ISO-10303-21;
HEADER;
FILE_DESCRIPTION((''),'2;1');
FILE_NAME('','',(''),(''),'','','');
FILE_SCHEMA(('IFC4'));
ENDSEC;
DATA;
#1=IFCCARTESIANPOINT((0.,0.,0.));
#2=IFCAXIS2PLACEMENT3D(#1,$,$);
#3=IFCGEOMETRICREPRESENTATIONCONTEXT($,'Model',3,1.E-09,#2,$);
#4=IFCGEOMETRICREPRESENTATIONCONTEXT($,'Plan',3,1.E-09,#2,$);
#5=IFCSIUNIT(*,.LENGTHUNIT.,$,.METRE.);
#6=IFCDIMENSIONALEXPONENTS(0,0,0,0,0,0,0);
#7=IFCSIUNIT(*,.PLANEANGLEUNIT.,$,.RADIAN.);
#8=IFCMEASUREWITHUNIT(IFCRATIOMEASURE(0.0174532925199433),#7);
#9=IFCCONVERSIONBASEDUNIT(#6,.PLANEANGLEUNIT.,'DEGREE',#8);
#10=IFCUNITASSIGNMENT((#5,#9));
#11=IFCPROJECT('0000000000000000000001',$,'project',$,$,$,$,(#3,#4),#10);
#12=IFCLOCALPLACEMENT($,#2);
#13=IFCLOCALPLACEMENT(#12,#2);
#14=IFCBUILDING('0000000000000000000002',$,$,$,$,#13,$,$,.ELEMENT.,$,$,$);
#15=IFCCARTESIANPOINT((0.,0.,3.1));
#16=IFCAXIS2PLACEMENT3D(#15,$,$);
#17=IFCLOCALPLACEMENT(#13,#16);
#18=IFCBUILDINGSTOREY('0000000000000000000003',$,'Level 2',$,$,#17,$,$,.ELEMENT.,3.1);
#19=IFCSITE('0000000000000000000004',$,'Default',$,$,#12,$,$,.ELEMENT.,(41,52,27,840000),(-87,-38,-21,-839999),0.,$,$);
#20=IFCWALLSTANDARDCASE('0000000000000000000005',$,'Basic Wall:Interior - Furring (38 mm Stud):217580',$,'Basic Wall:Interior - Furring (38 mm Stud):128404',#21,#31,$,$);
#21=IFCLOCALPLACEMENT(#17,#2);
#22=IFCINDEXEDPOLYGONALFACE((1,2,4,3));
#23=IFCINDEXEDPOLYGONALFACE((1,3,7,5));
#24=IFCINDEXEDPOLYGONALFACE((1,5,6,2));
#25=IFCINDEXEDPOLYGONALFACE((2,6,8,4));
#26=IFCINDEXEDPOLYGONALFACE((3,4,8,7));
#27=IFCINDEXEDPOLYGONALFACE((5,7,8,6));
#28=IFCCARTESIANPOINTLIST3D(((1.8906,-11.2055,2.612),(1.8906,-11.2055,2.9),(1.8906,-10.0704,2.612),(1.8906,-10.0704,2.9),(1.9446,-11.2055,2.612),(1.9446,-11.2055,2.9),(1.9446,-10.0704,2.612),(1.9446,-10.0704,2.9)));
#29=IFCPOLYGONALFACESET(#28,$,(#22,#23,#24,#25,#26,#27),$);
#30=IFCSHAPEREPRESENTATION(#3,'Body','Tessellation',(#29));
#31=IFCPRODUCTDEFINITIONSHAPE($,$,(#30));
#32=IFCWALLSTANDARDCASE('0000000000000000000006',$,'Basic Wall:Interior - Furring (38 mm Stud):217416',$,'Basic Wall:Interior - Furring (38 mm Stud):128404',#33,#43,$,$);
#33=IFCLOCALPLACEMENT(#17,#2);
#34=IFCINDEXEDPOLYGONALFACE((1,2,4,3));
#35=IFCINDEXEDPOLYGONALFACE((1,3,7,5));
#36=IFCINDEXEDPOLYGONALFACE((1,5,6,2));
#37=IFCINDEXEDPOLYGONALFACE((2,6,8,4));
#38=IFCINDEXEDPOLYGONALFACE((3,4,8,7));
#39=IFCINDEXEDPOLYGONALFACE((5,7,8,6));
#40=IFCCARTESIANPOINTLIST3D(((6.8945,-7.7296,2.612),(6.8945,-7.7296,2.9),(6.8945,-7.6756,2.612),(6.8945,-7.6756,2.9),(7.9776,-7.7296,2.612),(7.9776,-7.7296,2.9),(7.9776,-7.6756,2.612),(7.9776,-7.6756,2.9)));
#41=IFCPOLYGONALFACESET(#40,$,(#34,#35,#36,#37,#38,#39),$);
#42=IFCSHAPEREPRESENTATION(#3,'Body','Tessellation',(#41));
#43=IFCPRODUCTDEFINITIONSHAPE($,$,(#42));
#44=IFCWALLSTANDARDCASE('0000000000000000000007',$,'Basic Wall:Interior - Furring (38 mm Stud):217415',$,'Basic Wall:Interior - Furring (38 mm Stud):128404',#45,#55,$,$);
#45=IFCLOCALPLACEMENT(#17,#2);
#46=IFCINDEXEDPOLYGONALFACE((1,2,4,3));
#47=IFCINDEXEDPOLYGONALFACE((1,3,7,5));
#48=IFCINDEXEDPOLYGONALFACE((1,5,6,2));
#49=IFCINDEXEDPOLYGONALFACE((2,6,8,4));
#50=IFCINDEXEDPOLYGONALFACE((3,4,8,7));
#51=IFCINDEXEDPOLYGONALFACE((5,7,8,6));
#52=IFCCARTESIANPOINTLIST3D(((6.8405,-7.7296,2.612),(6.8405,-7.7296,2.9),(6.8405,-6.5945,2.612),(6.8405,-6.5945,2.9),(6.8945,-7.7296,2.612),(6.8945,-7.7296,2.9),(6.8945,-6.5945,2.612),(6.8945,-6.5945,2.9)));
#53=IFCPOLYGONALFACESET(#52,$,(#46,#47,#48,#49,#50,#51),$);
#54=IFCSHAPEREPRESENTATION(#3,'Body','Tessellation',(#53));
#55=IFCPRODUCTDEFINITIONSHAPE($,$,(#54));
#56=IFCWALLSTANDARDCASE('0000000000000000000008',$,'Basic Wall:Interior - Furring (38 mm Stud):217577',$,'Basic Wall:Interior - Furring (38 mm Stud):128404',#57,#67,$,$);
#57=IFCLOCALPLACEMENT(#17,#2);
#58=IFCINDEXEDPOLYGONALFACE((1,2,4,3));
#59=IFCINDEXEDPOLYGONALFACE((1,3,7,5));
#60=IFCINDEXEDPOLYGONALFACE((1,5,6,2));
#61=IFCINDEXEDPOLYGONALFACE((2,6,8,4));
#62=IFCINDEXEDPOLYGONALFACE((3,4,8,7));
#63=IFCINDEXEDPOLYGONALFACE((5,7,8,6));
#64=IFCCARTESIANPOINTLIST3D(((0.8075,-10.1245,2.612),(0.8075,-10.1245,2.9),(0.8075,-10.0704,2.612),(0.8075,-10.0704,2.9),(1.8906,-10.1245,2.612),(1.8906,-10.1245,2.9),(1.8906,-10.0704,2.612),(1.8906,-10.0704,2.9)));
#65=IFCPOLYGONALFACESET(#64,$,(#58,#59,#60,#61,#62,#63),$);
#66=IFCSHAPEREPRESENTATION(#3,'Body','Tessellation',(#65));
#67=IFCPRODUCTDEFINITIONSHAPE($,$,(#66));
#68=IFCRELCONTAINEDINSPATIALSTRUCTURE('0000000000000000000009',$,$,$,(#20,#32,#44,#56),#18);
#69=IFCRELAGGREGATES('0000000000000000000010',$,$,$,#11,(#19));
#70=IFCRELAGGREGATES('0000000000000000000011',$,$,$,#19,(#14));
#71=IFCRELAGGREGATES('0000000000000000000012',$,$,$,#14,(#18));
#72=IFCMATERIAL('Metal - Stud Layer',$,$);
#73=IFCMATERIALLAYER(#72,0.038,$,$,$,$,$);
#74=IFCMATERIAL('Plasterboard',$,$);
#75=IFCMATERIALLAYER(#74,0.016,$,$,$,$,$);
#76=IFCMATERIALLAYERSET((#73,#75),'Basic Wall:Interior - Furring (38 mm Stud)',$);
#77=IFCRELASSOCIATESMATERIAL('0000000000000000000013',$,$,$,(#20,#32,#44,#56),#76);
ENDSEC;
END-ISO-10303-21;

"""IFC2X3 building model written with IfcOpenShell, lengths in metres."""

from ifc_helpers import new_model, entity, si_unit, converted_unit, frame, frame_2d, origin, place, context, project, spatial, rectangle, extrude, material, layer, layer_set, layer_usage, element, save


model = new_model("IFC2X3")

# Units and contexts
model_context = context("Model", 3, precision=1e-09, world=origin())
plan_context = context("Plan", 3, precision=1e-09, world=origin())
ifc_project = project(units=[si_unit("LENGTHUNIT", "METRE"), converted_unit("PLANEANGLEUNIT", "DEGREE", entity("IfcRatioMeasure", 0.0174532925199433), si_unit("PLANEANGLEUNIT", "RADIAN"), dimensions=[0, 0, 0, 0, 0, 0, 0])], contexts=[model_context, plan_context])

# Site, building, storey
site_placement = place(None, origin())
site = spatial("IfcSite", under=ifc_project, at=site_placement, Name="Default", CompositionType="ELEMENT", RefLatitude=(41, 52, 27, 840000), RefLongitude=(-87, -38, -21, -839999), RefElevation=0.0)
building_placement = place(site_placement, origin())
building = spatial("IfcBuilding", under=site, at=building_placement, CompositionType="ELEMENT")
storey_placement = place(building_placement, frame((0.0, 0.0, 3.1)))
storey = spatial("IfcBuildingStorey", under=building, at=storey_placement, Name="Level 2", CompositionType="ELEMENT", Elevation=3.1)

# Shared definitions
ifc_material_1 = material(Name="Plasterboard")
ifc_material_2 = material(Name="Metal - Stud Layer")

# Walls
ifc_layer_1 = layer(ifc_material_2, 0.038)
ifc_layer_2 = layer(ifc_material_1, 0.016)
ifc_layer_set_1 = layer_set([ifc_layer_1, ifc_layer_2], Name="Basic Wall:Interior - Furring (38 mm Stud)")
ifc_layer_usage_1 = layer_usage(ifc_layer_set_1, "AXIS2", "NEGATIVE", 0.027)
wall_1_placement = place(storey_placement, frame((1.9176, -10.0704, 2.612), z_axis=(0.0, 0.0, 1.0), x_axis=(0.0, -1.0, 0.0)))
element("IfcWallStandardCase", 1, at=wall_1_placement, inside=storey, material=ifc_layer_usage_1, Name="Basic Wall:Interior - Furring (38 mm Stud):217580", ObjectType="Basic Wall:Interior - Furring (38 mm Stud):128404", context=model_context, shape_type="SweptSolid", body=[
    extrude(rectangle(XDim=1.1351, YDim=0.054, at=frame_2d((0.5675, 0.0), x_axis=(-1.0, 0.0))), origin(), (0.0, 0.0, 1.0), 0.288),
])
wall_2_placement = place(storey_placement, frame((7.9776, -7.7026, 2.612), z_axis=(0.0, 0.0, 1.0), x_axis=(-1.0, 0.0, 0.0)))
element("IfcWallStandardCase", 2, at=wall_2_placement, inside=storey, material=ifc_layer_usage_1, Name="Basic Wall:Interior - Furring (38 mm Stud):217416", ObjectType="Basic Wall:Interior - Furring (38 mm Stud):128404", context=model_context, shape_type="SweptSolid", body=[
    extrude(rectangle(XDim=1.0831, YDim=0.054, at=frame_2d((0.5415, 0.0), x_axis=(-1.0, 0.0))), origin(), (0.0, 0.0, 1.0), 0.288),
])
wall_3_placement = place(storey_placement, frame((6.8675, -7.7296, 2.612), z_axis=(0.0, 0.0, 1.0), x_axis=(0.0, 1.0, 0.0)))
element("IfcWallStandardCase", 3, at=wall_3_placement, inside=storey, material=ifc_layer_usage_1, Name="Basic Wall:Interior - Furring (38 mm Stud):217415", ObjectType="Basic Wall:Interior - Furring (38 mm Stud):128404", context=model_context, shape_type="SweptSolid", body=[
    extrude(rectangle(XDim=1.1351, YDim=0.054, at=frame_2d((0.5675, 0.0), x_axis=(-1.0, 0.0))), origin(), (0.0, 0.0, 1.0), 0.288),
])
wall_4_placement = place(storey_placement, frame((0.8075, -10.0975, 2.612)))
element("IfcWallStandardCase", 4, at=wall_4_placement, inside=storey, material=ifc_layer_usage_1, Name="Basic Wall:Interior - Furring (38 mm Stud):217577", ObjectType="Basic Wall:Interior - Furring (38 mm Stud):128404", context=model_context, shape_type="SweptSolid", body=[
    extrude(rectangle(XDim=1.0831, YDim=0.054, at=frame_2d((0.5415, 0.0), x_axis=(-1.0, 0.0))), origin(), (0.0, 0.0, 1.0), 0.288),
])

save(model, "model.ifc")
